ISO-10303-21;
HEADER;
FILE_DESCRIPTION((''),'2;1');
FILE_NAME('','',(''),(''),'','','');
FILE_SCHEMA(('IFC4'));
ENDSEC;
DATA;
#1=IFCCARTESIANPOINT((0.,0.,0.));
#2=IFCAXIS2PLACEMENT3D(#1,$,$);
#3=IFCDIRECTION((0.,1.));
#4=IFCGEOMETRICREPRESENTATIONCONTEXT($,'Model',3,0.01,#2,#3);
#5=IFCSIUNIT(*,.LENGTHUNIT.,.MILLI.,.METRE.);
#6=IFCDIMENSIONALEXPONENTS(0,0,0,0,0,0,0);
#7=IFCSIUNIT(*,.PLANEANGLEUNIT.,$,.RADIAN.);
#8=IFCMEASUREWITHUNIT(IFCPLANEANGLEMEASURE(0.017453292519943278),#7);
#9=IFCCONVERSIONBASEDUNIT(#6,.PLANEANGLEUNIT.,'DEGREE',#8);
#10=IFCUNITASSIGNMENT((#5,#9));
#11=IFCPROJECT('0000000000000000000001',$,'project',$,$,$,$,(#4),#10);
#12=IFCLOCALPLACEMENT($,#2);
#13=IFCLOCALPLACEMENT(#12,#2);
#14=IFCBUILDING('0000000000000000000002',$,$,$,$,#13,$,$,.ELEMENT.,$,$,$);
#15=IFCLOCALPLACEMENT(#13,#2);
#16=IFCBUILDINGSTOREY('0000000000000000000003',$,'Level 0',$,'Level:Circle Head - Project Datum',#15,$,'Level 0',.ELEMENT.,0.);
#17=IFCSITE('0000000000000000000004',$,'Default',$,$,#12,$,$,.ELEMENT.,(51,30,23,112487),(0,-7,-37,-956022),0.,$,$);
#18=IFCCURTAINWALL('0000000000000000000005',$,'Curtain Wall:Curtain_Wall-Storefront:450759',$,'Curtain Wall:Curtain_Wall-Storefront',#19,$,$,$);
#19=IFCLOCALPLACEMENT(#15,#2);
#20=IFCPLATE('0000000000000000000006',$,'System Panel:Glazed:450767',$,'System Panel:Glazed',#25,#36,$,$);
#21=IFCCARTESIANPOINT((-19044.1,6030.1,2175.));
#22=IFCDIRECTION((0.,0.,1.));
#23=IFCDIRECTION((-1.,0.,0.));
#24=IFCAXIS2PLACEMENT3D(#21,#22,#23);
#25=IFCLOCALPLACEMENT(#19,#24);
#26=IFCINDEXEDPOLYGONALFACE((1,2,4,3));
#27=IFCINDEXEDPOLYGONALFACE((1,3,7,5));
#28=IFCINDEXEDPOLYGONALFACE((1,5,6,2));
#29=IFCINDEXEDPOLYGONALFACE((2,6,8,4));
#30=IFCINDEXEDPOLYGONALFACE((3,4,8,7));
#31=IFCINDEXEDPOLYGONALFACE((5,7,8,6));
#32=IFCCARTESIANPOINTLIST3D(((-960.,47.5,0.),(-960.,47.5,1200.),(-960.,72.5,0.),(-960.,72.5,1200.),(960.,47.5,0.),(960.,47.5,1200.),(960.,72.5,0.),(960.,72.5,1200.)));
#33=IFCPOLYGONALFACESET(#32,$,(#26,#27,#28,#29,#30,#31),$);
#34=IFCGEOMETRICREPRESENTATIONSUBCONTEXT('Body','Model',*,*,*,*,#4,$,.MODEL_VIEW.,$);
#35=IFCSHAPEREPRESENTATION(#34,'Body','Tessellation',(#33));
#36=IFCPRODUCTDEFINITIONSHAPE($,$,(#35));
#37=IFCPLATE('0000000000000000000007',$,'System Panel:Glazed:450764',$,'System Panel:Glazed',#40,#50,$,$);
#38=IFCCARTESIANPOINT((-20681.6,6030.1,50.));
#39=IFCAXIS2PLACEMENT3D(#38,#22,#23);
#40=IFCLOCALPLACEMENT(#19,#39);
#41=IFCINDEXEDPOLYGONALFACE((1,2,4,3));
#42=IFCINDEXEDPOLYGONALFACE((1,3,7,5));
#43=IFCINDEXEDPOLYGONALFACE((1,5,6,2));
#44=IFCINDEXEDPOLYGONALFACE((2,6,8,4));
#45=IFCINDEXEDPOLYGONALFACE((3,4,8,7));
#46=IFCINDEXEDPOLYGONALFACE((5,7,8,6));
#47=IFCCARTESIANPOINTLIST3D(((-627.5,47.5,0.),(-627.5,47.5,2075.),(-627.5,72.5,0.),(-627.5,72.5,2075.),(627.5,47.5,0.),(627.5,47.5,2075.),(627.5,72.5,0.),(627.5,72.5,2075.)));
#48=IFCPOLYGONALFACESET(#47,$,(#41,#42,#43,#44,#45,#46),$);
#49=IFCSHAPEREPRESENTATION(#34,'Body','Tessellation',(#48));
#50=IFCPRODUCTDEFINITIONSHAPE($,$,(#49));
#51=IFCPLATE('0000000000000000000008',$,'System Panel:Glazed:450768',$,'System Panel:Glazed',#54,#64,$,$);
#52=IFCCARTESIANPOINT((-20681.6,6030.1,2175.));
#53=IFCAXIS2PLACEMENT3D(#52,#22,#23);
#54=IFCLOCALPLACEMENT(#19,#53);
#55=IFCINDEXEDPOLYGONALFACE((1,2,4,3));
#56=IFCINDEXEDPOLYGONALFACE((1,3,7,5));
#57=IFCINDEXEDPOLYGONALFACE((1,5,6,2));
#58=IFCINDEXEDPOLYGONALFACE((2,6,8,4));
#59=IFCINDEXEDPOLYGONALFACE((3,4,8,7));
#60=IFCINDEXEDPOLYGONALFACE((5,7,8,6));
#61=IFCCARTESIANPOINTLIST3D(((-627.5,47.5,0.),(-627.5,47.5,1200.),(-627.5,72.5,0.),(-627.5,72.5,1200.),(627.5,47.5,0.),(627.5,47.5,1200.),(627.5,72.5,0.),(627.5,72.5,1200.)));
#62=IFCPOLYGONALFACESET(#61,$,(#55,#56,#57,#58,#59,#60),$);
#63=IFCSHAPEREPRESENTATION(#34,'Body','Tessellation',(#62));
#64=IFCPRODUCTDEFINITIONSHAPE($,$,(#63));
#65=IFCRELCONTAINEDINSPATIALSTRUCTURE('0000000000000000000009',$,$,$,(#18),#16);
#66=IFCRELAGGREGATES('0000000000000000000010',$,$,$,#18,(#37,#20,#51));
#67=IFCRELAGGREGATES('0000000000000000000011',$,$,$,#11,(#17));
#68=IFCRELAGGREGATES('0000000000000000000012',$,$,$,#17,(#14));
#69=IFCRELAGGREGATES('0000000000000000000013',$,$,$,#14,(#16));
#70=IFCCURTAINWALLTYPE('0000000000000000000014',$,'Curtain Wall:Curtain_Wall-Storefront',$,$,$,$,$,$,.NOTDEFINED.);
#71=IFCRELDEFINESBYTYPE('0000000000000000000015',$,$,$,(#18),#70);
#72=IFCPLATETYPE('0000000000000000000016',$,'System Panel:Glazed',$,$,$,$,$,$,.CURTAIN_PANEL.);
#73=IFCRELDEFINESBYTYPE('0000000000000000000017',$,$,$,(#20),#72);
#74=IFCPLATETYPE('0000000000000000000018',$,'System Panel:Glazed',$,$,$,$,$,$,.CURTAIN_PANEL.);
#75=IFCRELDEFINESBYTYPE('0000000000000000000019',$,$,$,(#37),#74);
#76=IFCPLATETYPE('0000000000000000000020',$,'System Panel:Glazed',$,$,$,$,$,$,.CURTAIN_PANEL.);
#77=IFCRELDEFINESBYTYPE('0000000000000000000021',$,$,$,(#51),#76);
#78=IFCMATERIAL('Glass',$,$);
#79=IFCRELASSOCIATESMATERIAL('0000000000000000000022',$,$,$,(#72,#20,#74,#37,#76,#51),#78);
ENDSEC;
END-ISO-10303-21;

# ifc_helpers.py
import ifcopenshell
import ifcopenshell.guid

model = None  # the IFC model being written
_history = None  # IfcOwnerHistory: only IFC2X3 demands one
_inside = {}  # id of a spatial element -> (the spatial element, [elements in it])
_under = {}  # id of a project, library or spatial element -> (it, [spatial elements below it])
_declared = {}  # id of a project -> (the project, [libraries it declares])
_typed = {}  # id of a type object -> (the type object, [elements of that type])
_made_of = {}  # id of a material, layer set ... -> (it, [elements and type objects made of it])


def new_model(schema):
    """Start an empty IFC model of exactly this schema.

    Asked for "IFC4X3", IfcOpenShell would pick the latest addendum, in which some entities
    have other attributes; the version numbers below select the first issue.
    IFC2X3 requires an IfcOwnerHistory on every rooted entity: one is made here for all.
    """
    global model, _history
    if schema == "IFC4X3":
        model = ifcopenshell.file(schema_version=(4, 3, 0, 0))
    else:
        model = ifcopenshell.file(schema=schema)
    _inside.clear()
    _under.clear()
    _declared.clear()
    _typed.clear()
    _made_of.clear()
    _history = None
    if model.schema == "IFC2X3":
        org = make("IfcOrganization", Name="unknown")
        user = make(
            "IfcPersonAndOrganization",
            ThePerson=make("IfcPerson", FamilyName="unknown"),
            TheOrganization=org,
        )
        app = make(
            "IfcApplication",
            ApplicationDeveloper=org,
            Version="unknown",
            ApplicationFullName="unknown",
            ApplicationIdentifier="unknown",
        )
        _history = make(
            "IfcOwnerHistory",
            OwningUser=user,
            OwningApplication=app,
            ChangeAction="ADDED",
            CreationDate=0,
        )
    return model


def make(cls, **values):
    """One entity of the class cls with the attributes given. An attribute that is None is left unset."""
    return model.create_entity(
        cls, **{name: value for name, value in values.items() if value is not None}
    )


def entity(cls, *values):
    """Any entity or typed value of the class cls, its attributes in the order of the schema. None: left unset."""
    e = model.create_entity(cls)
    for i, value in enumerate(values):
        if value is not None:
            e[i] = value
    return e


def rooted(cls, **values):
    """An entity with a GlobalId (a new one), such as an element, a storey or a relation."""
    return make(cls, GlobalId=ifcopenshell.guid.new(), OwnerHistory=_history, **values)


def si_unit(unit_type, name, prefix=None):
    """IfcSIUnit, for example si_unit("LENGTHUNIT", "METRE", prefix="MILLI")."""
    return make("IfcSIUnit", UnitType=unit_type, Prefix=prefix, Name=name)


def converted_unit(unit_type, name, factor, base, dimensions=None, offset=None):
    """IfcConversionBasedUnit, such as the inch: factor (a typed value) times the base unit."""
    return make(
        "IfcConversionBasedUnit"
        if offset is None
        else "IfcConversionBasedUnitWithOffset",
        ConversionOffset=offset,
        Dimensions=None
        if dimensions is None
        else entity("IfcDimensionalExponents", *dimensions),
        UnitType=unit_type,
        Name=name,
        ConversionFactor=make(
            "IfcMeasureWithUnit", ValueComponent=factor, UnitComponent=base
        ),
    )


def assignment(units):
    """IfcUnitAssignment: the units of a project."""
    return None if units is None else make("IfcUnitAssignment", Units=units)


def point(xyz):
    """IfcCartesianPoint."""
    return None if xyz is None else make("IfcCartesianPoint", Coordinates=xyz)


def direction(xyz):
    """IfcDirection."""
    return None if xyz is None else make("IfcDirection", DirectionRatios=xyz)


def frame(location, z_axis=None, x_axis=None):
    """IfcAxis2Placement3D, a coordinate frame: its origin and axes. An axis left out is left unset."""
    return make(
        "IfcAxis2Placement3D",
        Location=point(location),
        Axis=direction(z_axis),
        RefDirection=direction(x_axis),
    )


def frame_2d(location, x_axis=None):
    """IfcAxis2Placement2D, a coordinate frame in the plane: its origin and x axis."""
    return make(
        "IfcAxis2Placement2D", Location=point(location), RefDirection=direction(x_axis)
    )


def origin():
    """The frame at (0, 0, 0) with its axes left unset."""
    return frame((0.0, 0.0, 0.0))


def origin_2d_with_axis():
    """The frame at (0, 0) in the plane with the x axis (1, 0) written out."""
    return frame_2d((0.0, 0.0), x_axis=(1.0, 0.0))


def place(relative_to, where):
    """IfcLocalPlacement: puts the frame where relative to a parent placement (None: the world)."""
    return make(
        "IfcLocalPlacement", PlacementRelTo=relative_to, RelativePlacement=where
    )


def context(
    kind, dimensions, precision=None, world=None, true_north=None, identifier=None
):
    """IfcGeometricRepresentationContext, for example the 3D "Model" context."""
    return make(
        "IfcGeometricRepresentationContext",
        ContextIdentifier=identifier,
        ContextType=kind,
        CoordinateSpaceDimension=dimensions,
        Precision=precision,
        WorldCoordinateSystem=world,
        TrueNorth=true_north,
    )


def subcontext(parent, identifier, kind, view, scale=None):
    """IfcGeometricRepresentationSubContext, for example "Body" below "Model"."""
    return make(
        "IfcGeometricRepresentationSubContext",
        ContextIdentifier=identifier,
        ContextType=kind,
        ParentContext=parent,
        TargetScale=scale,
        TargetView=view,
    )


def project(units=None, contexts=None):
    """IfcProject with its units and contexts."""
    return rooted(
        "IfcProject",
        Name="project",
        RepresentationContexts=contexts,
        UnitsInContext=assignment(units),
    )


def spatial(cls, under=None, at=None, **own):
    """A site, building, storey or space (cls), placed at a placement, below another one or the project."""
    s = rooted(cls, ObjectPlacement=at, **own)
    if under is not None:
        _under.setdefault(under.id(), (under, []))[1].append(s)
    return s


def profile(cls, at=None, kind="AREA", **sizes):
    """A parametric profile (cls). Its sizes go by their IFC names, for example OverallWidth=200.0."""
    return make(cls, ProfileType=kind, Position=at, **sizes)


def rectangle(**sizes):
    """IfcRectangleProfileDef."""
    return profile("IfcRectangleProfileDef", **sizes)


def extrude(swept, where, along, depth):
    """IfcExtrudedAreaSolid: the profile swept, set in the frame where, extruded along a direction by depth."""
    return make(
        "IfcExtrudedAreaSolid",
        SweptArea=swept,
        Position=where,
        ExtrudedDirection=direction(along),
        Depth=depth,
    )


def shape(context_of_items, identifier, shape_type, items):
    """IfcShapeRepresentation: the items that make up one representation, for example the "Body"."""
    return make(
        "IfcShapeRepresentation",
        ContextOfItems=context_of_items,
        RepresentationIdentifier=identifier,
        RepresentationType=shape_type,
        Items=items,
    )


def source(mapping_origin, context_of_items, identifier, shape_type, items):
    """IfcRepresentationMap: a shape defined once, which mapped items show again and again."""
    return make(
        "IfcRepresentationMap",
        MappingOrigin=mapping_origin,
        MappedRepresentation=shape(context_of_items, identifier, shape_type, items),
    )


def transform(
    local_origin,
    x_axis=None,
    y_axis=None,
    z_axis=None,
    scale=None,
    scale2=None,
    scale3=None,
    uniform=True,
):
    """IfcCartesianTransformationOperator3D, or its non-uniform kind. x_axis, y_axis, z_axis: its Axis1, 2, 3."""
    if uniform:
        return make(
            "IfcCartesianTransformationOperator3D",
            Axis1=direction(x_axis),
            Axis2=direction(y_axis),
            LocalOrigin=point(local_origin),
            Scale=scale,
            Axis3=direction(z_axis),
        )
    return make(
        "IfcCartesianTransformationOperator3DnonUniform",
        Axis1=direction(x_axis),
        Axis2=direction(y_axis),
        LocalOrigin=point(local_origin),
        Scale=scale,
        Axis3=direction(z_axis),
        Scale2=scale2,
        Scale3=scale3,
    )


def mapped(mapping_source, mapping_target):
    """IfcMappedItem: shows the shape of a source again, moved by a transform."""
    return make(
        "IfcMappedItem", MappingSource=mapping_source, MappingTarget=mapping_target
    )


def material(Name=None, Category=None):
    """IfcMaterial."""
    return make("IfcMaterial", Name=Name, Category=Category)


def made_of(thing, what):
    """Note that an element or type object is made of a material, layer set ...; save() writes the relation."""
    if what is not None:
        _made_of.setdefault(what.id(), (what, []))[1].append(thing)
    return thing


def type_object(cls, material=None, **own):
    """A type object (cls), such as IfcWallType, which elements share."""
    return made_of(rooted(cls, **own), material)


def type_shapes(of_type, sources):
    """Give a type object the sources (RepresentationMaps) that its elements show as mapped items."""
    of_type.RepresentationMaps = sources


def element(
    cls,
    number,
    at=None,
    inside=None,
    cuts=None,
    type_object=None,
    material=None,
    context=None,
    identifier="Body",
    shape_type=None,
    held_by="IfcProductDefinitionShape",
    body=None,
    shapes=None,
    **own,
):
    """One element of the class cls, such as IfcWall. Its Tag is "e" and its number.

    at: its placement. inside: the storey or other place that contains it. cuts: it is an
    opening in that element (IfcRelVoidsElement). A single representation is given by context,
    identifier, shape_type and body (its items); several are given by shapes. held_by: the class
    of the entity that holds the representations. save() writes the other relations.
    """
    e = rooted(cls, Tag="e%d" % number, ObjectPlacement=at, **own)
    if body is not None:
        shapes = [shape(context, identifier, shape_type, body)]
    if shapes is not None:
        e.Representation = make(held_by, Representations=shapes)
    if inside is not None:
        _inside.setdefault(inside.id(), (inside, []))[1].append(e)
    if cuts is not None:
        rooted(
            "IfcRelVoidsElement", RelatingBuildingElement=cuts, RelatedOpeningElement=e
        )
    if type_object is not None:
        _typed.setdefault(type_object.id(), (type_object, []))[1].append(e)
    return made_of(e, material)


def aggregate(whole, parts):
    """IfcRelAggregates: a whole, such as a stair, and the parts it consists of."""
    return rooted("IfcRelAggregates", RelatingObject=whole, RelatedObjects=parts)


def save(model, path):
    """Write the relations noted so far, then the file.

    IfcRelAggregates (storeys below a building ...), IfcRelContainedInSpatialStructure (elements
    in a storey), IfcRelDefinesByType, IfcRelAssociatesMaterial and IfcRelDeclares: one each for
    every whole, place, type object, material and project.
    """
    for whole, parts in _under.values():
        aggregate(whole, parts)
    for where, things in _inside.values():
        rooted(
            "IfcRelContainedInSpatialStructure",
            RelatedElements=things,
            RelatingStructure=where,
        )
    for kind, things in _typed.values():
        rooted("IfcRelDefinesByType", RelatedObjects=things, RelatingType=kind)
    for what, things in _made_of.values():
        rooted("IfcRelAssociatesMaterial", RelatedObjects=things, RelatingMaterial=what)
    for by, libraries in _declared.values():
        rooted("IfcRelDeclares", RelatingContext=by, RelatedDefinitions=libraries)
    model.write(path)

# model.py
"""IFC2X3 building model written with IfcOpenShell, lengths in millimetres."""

from ifc_helpers import new_model, entity, si_unit, converted_unit, direction, frame, origin, origin_2d_with_axis, place, context, subcontext, project, spatial, rectangle, extrude, source, transform, mapped, material, type_object, type_shapes, element, aggregate, save


model = new_model("IFC2X3")

# Units and contexts
model_context = context("Model", 3, precision=0.01, world=origin(), true_north=direction((0.0, 1.0)))
body_context = subcontext(model_context, "Body", "Model", "MODEL_VIEW")
ifc_project = project(units=[si_unit("LENGTHUNIT", "METRE", prefix="MILLI"), converted_unit("PLANEANGLEUNIT", "DEGREE", entity("IfcPlaneAngleMeasure", 0.017453292519943278), si_unit("PLANEANGLEUNIT", "RADIAN"), dimensions=[0, 0, 0, 0, 0, 0, 0])], contexts=[model_context])

# Site, building, storey
site_placement = place(None, origin())
site = spatial("IfcSite", under=ifc_project, at=site_placement, Name="Default", CompositionType="ELEMENT", RefLatitude=(51, 30, 23, 112487), RefLongitude=(0, -7, -37, -956022), RefElevation=0.0)
building_placement = place(site_placement, origin())
building = spatial("IfcBuilding", under=site, at=building_placement, CompositionType="ELEMENT")
storey_placement = place(building_placement, origin())
storey = spatial("IfcBuildingStorey", under=building, at=storey_placement, Name="Level 0", ObjectType="Level:Circle Head - Project Datum", LongName="Level 0", CompositionType="ELEMENT", Elevation=0.0)

# Curtain wall, plates
curtain_wall_type = type_object("IfcCurtainWallType", Name="Curtain Wall:Curtain_Wall-Storefront", PredefinedType="NOTDEFINED")
curtain_wall_placement = place(storey_placement, origin())
curtain_wall = element("IfcCurtainWall", 1, at=curtain_wall_placement, inside=storey, type_object=curtain_wall_type, Name="Curtain Wall:Curtain_Wall-Storefront:450759", ObjectType="Curtain Wall:Curtain_Wall-Storefront")
ifc_material_1 = material(Name="Glass")
plate_type_1 = type_object("IfcPlateType", Name="System Panel:Glazed", PredefinedType="CURTAIN_PANEL", material=ifc_material_1)
shared_shape_1 = source(origin(), body_context, "Body", "SweptSolid", [
    extrude(rectangle(XDim=25.0, YDim=1920.0, at=origin_2d_with_axis()), frame((0.0, 60.0, 0.0), z_axis=(0.0, 0.0, 1.0), x_axis=(0.0, 1.0, 0.0)), (0.0, 0.0, 1.0), 1200.0),
])
type_shapes(plate_type_1, [shared_shape_1])
plate_1_placement = place(curtain_wall_placement, frame((-19044.1, 6030.1, 2175.0), z_axis=(0.0, 0.0, 1.0), x_axis=(-1.0, 0.0, 0.0)))
plate_1 = element("IfcPlate", 2, at=plate_1_placement, type_object=plate_type_1, material=ifc_material_1, Name="System Panel:Glazed:450767", ObjectType="System Panel:Glazed", context=body_context, shape_type="MappedRepresentation", body=[
    mapped(shared_shape_1, transform((0.0, 0.0, 0.0), scale=1.0)),
])
plate_type_2 = type_object("IfcPlateType", Name="System Panel:Glazed", PredefinedType="CURTAIN_PANEL", material=ifc_material_1)
shared_shape_2 = source(origin(), body_context, "Body", "SweptSolid", [
    extrude(rectangle(XDim=25.0, YDim=1255.0, at=origin_2d_with_axis()), frame((0.0, 60.0, 0.0), z_axis=(0.0, 0.0, 1.0), x_axis=(0.0, 1.0, 0.0)), (0.0, 0.0, 1.0), 2075.0),
])
type_shapes(plate_type_2, [shared_shape_2])
plate_2_placement = place(curtain_wall_placement, frame((-20681.6, 6030.1, 50.0), z_axis=(0.0, 0.0, 1.0), x_axis=(-1.0, 0.0, 0.0)))
plate_2 = element("IfcPlate", 3, at=plate_2_placement, type_object=plate_type_2, material=ifc_material_1, Name="System Panel:Glazed:450764", ObjectType="System Panel:Glazed", context=body_context, shape_type="MappedRepresentation", body=[
    mapped(shared_shape_2, transform((0.0, 0.0, 0.0), scale=1.0)),
])
plate_type_3 = type_object("IfcPlateType", Name="System Panel:Glazed", PredefinedType="CURTAIN_PANEL", material=ifc_material_1)
shared_shape_3 = source(origin(), body_context, "Body", "SweptSolid", [
    extrude(rectangle(XDim=25.0, YDim=1255.0, at=origin_2d_with_axis()), frame((0.0, 60.0, 0.0), z_axis=(0.0, 0.0, 1.0), x_axis=(0.0, 1.0, 0.0)), (0.0, 0.0, 1.0), 1200.0),
])
type_shapes(plate_type_3, [shared_shape_3])
plate_3_placement = place(curtain_wall_placement, frame((-20681.6, 6030.1, 2175.0), z_axis=(0.0, 0.0, 1.0), x_axis=(-1.0, 0.0, 0.0)))
plate_3 = element("IfcPlate", 4, at=plate_3_placement, type_object=plate_type_3, material=ifc_material_1, Name="System Panel:Glazed:450768", ObjectType="System Panel:Glazed", context=body_context, shape_type="MappedRepresentation", body=[
    mapped(shared_shape_3, transform((0.0, 0.0, 0.0), scale=1.0)),
])
aggregate(curtain_wall, [plate_2, plate_1, plate_3])

save(model, "model.ifc")
